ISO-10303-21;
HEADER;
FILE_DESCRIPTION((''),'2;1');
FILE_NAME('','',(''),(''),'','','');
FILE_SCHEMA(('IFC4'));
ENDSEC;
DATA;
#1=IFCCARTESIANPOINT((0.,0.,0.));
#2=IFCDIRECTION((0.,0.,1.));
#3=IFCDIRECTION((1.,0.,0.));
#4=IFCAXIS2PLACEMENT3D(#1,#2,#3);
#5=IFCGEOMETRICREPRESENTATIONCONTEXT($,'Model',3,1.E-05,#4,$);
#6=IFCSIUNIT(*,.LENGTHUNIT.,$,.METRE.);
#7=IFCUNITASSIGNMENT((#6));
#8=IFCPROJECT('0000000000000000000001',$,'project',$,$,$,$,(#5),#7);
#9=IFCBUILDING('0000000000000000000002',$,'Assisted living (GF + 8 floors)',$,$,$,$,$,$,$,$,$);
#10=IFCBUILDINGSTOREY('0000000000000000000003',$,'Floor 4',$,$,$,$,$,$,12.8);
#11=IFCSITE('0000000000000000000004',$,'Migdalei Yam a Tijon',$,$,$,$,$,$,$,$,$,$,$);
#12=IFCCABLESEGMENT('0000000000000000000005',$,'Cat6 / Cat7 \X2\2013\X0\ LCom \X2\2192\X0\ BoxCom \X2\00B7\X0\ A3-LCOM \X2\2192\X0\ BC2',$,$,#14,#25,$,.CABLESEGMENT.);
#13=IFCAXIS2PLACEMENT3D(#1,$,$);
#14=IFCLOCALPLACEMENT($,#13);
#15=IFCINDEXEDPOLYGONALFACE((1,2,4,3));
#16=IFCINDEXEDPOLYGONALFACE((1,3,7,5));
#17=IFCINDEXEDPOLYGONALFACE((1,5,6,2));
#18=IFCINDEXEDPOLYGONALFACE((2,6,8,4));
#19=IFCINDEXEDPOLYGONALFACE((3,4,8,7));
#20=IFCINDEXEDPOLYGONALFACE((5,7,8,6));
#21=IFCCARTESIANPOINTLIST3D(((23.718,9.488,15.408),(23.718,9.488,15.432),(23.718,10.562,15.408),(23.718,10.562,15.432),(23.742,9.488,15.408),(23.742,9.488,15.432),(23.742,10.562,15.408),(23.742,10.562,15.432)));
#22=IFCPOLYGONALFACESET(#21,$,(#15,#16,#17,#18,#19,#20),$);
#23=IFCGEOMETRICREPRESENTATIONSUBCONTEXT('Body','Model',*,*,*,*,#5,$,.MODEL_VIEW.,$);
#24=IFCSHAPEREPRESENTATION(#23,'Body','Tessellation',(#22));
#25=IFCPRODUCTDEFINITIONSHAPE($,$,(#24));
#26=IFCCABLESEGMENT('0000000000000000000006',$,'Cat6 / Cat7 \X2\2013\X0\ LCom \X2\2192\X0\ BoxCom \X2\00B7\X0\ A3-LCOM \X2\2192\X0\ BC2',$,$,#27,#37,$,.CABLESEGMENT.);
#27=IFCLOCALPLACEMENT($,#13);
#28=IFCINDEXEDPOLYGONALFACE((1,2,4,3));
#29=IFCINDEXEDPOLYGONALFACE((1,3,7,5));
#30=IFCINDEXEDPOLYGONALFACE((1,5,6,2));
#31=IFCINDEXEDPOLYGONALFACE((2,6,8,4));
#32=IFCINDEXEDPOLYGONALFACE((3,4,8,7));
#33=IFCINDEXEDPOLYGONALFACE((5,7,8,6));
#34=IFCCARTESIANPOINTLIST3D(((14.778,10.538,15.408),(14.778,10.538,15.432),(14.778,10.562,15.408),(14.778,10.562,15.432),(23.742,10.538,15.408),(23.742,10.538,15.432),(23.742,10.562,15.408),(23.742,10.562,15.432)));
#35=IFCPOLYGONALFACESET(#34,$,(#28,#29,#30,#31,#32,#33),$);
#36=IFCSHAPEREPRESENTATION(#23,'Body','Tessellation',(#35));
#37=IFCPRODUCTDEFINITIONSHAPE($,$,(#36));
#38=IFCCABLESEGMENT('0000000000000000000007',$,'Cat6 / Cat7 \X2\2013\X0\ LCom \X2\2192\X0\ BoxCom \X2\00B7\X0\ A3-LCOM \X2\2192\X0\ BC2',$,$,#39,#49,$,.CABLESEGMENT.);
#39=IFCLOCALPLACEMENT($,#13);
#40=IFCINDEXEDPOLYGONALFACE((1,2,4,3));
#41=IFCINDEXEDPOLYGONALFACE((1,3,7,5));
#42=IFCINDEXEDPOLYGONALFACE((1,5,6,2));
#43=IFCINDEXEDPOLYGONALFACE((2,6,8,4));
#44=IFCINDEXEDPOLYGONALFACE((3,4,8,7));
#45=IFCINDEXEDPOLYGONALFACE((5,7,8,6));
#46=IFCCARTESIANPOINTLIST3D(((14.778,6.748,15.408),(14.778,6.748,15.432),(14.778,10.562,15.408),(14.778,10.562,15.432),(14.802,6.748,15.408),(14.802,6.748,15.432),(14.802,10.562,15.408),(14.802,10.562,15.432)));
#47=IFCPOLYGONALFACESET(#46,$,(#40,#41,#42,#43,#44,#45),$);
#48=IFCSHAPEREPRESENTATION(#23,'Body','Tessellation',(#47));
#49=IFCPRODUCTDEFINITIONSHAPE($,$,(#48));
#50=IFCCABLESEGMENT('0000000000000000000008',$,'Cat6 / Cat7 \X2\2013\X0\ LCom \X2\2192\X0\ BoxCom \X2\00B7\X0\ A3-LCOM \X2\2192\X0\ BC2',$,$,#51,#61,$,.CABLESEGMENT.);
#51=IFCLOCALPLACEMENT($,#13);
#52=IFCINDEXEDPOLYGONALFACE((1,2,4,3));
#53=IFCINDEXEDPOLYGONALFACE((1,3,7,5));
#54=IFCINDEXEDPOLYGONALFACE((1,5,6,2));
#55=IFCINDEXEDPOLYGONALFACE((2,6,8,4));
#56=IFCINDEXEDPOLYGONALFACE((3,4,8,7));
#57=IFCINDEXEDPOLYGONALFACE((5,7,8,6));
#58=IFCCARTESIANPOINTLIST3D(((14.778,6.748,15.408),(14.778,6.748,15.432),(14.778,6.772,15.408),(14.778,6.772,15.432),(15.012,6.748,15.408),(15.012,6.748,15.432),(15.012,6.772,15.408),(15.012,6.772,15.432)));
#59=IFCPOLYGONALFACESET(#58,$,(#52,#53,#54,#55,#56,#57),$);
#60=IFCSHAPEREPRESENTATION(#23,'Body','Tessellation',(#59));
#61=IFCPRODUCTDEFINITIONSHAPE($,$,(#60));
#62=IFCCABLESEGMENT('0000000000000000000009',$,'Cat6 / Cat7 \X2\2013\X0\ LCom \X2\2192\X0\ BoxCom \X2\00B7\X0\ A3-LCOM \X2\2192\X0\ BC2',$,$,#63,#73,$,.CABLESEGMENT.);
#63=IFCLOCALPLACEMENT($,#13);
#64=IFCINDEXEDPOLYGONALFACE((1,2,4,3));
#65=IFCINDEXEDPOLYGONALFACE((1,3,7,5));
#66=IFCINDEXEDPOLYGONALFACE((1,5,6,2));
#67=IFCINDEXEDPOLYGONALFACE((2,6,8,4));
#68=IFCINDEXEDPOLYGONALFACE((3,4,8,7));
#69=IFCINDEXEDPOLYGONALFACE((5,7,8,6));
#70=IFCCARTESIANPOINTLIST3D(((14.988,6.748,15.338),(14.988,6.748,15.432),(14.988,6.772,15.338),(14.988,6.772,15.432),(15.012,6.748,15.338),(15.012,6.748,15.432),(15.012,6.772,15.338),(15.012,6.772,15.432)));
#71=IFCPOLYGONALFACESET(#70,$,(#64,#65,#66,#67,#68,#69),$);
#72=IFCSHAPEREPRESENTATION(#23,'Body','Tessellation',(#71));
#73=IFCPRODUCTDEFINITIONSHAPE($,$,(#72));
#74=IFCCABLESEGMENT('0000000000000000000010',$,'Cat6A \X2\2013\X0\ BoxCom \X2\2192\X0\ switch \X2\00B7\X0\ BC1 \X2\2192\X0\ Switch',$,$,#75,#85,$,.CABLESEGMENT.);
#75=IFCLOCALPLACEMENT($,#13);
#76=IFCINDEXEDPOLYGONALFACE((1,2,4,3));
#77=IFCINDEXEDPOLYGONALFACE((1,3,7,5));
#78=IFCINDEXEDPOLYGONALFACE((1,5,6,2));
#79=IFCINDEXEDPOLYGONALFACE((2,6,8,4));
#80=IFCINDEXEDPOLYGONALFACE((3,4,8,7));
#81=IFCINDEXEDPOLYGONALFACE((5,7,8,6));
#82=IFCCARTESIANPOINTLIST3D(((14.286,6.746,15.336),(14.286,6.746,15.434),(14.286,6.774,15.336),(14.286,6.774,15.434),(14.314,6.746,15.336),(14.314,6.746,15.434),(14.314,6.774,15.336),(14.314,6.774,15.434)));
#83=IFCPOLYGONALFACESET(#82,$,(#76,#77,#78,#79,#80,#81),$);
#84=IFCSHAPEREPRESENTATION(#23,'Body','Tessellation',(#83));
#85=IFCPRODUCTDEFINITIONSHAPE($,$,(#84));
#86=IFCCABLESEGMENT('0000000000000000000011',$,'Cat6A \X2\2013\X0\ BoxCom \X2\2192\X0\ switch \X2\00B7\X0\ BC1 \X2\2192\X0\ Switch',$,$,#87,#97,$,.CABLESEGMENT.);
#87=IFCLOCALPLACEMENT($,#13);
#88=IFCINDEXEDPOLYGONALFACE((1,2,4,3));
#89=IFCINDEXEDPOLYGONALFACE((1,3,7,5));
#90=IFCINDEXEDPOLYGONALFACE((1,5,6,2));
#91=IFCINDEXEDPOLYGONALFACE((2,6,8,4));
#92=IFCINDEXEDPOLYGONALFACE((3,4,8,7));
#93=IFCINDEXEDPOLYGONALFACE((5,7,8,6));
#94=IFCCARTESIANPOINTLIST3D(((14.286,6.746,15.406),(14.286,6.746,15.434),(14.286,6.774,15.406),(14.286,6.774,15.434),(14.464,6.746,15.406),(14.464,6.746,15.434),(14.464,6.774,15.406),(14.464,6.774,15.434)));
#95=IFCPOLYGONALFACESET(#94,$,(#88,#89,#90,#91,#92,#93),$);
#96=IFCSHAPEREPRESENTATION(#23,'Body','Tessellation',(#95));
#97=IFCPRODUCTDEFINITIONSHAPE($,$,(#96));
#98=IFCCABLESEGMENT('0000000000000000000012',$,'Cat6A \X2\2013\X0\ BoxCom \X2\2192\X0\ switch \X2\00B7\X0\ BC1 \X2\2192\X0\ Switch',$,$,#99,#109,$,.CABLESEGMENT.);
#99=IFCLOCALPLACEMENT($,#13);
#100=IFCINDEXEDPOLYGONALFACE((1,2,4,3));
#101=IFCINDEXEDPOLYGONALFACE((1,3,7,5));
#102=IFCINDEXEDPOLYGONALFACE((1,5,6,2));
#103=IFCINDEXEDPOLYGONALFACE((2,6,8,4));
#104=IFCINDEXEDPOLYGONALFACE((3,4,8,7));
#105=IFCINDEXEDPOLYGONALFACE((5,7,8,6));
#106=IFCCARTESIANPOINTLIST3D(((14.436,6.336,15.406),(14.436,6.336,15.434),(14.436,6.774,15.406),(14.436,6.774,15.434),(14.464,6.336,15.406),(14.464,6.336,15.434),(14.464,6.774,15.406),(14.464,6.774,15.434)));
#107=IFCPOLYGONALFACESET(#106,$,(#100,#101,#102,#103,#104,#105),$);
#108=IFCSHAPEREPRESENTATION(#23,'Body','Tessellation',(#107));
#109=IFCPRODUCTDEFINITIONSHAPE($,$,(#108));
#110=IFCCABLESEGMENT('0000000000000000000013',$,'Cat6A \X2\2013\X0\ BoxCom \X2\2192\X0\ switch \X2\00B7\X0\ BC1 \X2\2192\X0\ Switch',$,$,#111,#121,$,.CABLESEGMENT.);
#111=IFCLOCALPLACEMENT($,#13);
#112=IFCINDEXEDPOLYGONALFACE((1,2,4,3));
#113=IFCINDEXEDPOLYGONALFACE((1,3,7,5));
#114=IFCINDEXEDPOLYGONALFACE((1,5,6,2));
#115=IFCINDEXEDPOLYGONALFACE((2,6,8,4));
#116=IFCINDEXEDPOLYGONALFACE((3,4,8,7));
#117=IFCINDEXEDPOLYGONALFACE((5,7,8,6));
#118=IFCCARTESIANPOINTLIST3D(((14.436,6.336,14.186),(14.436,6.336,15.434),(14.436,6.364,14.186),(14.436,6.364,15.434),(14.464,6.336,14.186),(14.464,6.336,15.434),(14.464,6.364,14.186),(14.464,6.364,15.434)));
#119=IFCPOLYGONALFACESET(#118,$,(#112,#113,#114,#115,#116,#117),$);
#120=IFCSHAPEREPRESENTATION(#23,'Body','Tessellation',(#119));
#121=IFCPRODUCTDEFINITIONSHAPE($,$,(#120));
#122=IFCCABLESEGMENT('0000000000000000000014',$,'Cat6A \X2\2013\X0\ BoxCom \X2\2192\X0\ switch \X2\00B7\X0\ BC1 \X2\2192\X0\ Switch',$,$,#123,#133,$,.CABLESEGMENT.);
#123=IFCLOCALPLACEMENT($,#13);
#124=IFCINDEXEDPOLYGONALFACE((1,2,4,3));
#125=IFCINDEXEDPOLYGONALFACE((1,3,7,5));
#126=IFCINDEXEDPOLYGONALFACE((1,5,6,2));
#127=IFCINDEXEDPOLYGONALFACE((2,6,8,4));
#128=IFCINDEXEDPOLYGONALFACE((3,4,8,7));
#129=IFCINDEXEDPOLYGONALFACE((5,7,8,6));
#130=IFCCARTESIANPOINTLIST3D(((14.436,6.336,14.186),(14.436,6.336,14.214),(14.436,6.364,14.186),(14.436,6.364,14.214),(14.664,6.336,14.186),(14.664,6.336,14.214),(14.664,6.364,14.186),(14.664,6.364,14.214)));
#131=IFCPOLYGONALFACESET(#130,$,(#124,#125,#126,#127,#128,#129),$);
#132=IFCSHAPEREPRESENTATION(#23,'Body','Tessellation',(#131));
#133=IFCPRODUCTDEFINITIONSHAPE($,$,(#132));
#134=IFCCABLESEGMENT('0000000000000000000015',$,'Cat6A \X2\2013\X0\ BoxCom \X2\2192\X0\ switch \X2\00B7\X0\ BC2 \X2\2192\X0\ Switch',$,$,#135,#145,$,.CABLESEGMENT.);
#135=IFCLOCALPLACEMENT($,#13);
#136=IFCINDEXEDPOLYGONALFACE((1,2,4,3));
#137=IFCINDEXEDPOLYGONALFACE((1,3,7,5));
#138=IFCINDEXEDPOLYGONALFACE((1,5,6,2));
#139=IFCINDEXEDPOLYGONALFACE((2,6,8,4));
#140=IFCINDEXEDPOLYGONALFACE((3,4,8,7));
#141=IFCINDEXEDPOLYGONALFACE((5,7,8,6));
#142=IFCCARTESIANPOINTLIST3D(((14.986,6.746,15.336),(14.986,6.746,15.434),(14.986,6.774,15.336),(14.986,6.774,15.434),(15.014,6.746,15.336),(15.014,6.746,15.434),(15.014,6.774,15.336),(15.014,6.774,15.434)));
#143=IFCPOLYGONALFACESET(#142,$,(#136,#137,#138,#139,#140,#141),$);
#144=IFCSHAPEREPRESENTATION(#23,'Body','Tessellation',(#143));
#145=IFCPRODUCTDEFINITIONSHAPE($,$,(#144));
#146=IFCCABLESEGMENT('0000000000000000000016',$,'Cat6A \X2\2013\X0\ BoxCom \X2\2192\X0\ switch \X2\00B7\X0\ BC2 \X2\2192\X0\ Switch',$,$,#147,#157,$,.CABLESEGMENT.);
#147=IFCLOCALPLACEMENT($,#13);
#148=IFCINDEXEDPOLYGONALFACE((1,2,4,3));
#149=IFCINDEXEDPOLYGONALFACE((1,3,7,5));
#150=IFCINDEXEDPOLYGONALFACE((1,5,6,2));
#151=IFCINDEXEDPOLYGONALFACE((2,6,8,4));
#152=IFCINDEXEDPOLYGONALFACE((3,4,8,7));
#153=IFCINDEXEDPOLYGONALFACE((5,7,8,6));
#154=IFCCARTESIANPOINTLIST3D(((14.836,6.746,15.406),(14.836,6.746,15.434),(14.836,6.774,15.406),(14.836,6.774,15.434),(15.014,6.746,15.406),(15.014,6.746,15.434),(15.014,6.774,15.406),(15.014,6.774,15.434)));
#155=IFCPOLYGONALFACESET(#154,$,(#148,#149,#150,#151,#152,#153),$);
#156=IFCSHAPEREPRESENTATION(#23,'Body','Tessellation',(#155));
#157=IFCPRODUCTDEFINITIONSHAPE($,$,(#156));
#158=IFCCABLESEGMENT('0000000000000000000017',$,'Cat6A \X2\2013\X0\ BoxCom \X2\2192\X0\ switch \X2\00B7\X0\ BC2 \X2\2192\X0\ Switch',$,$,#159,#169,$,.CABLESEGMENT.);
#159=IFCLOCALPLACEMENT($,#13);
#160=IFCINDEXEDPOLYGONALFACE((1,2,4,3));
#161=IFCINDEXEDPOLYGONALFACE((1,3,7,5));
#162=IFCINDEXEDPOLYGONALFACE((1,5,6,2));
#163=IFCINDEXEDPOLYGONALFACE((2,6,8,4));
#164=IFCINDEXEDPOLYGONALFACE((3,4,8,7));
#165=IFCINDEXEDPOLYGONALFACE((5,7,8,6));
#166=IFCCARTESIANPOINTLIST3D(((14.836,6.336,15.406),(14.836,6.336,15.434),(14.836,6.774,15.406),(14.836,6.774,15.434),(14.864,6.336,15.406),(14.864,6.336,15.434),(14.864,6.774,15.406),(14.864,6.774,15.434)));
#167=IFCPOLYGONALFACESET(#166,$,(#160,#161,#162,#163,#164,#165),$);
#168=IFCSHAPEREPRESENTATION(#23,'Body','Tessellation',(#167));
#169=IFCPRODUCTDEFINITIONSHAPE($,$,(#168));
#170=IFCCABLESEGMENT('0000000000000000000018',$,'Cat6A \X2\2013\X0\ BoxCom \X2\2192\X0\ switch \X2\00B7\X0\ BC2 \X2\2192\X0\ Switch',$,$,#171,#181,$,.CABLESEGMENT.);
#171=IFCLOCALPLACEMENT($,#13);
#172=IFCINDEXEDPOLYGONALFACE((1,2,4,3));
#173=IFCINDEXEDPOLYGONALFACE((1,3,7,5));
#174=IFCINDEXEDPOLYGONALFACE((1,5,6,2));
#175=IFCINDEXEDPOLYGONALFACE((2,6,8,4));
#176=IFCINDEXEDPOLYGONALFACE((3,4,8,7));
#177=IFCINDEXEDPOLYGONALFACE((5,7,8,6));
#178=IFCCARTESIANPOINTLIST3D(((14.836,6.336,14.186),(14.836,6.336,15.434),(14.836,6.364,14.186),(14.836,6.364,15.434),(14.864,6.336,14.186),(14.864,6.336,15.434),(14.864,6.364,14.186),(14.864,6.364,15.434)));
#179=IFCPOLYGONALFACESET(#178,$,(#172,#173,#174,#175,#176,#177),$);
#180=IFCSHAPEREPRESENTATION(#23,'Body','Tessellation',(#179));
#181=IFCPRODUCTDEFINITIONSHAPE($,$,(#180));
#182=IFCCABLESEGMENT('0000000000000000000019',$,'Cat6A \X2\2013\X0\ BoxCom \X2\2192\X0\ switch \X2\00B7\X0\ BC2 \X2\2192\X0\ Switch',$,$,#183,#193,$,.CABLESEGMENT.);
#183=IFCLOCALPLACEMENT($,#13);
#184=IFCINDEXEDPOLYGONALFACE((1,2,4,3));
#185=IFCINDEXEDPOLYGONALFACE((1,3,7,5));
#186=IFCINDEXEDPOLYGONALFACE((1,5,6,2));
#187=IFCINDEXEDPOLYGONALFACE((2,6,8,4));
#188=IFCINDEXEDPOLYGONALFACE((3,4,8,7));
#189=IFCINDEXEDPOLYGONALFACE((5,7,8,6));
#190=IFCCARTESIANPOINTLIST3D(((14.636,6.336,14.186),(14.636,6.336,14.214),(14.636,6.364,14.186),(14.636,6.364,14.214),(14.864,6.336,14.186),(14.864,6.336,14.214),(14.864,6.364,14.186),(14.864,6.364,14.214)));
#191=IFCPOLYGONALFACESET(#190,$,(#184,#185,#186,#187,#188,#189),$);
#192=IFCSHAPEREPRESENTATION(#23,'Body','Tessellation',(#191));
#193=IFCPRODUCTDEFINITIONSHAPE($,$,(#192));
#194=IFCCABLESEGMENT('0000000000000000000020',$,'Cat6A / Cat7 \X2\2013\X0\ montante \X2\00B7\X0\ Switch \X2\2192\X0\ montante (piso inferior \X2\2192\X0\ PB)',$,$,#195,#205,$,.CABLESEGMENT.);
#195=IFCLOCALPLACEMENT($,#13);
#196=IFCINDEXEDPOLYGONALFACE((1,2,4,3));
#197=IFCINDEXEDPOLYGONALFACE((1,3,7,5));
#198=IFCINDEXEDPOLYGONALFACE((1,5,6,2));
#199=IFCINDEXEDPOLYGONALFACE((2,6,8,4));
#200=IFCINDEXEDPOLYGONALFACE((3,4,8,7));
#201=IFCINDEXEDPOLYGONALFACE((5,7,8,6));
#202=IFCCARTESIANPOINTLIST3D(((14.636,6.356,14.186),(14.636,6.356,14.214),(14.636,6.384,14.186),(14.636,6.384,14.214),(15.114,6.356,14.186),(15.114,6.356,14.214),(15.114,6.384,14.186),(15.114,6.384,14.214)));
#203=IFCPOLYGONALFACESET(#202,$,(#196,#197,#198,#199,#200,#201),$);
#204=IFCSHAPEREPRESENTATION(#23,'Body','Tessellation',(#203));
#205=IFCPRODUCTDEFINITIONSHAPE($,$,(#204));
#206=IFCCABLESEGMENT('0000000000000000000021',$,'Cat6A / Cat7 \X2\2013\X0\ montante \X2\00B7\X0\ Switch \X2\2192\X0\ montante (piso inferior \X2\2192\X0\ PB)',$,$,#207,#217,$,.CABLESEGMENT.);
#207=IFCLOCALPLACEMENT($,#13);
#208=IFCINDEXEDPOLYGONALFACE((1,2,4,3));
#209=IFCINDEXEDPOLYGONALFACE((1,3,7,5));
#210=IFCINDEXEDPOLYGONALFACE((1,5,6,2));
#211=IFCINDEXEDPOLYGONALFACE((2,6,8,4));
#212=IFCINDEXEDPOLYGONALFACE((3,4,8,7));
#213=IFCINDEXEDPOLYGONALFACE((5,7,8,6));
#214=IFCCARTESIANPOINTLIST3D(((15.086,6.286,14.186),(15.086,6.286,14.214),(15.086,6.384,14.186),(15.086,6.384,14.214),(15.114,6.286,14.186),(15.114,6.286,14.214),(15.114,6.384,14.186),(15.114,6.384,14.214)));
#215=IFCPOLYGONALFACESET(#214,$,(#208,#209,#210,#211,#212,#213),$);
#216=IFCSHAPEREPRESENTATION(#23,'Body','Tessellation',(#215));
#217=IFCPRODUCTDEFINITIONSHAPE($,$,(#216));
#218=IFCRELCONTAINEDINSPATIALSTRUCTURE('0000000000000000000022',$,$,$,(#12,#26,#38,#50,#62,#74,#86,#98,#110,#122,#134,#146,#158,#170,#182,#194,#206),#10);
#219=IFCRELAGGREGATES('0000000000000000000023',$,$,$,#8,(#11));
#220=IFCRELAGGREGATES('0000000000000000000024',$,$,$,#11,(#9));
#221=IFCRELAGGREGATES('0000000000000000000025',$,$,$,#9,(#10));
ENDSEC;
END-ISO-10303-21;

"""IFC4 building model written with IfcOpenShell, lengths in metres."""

from ifc_helpers import new_model, si_unit, frame, origin_with_axes, context, subcontext, project, spatial, line, indexed_curve, outline, extrude, element, save


model = new_model("IFC4")

# Units and contexts
model_context = context("Model", 3, precision=1e-05, world=origin_with_axes())
body_context = subcontext(model_context, "Body", "Model", "MODEL_VIEW")
ifc_project = project(units=[si_unit("LENGTHUNIT", "METRE")], contexts=[model_context])

# Site, building, storey
site = spatial("IfcSite", under=ifc_project, Name="Migdalei Yam a Tijon")
building = spatial("IfcBuilding", under=site, Name="Assisted living (GF + 8 floors)")
storey = spatial("IfcBuildingStorey", under=building, Name="Floor 4", Elevation=12.8)

# Cable segments
element("IfcCableSegment", 1, inside=storey, Name="Cat6 / Cat7 – LCom → BoxCom · A3-LCOM → BC2", PredefinedType="CABLESEGMENT", context=body_context, shape_type="SweptSolid", body=[
    extrude(outline(indexed_curve([(0.0, 0.0), (0.024, 0.0), (0.024, 1.074), (0.0, 1.074)], segments=[line(1, 2, 3, 4, 1)])), frame((23.718, 9.488, 15.408), z_axis=(0.0, 0.0, 1.0), x_axis=(1.0, 0.0, 0.0)), (0.0, 0.0, 1.0), 0.024),
])
element("IfcCableSegment", 2, inside=storey, Name="Cat6 / Cat7 – LCom → BoxCom · A3-LCOM → BC2", PredefinedType="CABLESEGMENT", context=body_context, shape_type="SweptSolid", body=[
    extrude(outline(indexed_curve([(0.0, 0.0), (8.964, 0.0), (8.964, 0.024), (0.0, 0.024)], segments=[line(1, 2, 3, 4, 1)])), frame((14.778, 10.538, 15.408), z_axis=(0.0, 0.0, 1.0), x_axis=(1.0, 0.0, 0.0)), (0.0, 0.0, 1.0), 0.024),
])
element("IfcCableSegment", 3, inside=storey, Name="Cat6 / Cat7 – LCom → BoxCom · A3-LCOM → BC2", PredefinedType="CABLESEGMENT", context=body_context, shape_type="SweptSolid", body=[
    extrude(outline(indexed_curve([(0.0, 0.0), (0.024, 0.0), (0.024, 3.814), (0.0, 3.814)], segments=[line(1, 2, 3, 4, 1)])), frame((14.778, 6.748, 15.408), z_axis=(0.0, 0.0, 1.0), x_axis=(1.0, 0.0, 0.0)), (0.0, 0.0, 1.0), 0.024),
])
element("IfcCableSegment", 4, inside=storey, Name="Cat6 / Cat7 – LCom → BoxCom · A3-LCOM → BC2", PredefinedType="CABLESEGMENT", context=body_context, shape_type="SweptSolid", body=[
    extrude(outline(indexed_curve([(0.0, 0.0), (0.234, 0.0), (0.234, 0.024), (0.0, 0.024)], segments=[line(1, 2, 3, 4, 1)])), frame((14.778, 6.748, 15.408), z_axis=(0.0, 0.0, 1.0), x_axis=(1.0, 0.0, 0.0)), (0.0, 0.0, 1.0), 0.024),
])
element("IfcCableSegment", 5, inside=storey, Name="Cat6 / Cat7 – LCom → BoxCom · A3-LCOM → BC2", PredefinedType="CABLESEGMENT", context=body_context, shape_type="SweptSolid", body=[
    extrude(outline(indexed_curve([(0.0, 0.0), (0.024, 0.0), (0.024, 0.024), (0.0, 0.024)], segments=[line(1, 2, 3, 4, 1)])), frame((14.988, 6.748, 15.338), z_axis=(0.0, 0.0, 1.0), x_axis=(1.0, 0.0, 0.0)), (0.0, 0.0, 1.0), 0.094),
])
element("IfcCableSegment", 6, inside=storey, Name="Cat6A – BoxCom → switch · BC1 → Switch", PredefinedType="CABLESEGMENT", context=body_context, shape_type="SweptSolid", body=[
    extrude(outline(indexed_curve([(0.0, 0.0), (0.028, 0.0), (0.028, 0.028), (0.0, 0.028)], segments=[line(1, 2, 3, 4, 1)])), frame((14.286, 6.746, 15.336), z_axis=(0.0, 0.0, 1.0), x_axis=(1.0, 0.0, 0.0)), (0.0, 0.0, 1.0), 0.098),
])
element("IfcCableSegment", 7, inside=storey, Name="Cat6A – BoxCom → switch · BC1 → Switch", PredefinedType="CABLESEGMENT", context=body_context, shape_type="SweptSolid", body=[
    extrude(outline(indexed_curve([(0.0, 0.0), (0.178, 0.0), (0.178, 0.028), (0.0, 0.028)], segments=[line(1, 2, 3, 4, 1)])), frame((14.286, 6.746, 15.406), z_axis=(0.0, 0.0, 1.0), x_axis=(1.0, 0.0, 0.0)), (0.0, 0.0, 1.0), 0.028),
])
element("IfcCableSegment", 8, inside=storey, Name="Cat6A – BoxCom → switch · BC1 → Switch", PredefinedType="CABLESEGMENT", context=body_context, shape_type="SweptSolid", body=[
    extrude(outline(indexed_curve([(0.0, 0.0), (0.028, 0.0), (0.028, 0.438), (0.0, 0.438)], segments=[line(1, 2, 3, 4, 1)])), frame((14.436, 6.336, 15.406), z_axis=(0.0, 0.0, 1.0), x_axis=(1.0, 0.0, 0.0)), (0.0, 0.0, 1.0), 0.028),
])
element("IfcCableSegment", 9, inside=storey, Name="Cat6A – BoxCom → switch · BC1 → Switch", PredefinedType="CABLESEGMENT", context=body_context, shape_type="SweptSolid", body=[
    extrude(outline(indexed_curve([(0.0, 0.0), (0.028, 0.0), (0.028, 0.028), (0.0, 0.028)], segments=[line(1, 2, 3, 4, 1)])), frame((14.436, 6.336, 14.186), z_axis=(0.0, 0.0, 1.0), x_axis=(1.0, 0.0, 0.0)), (0.0, 0.0, 1.0), 1.248),
])
element("IfcCableSegment", 10, inside=storey, Name="Cat6A – BoxCom → switch · BC1 → Switch", PredefinedType="CABLESEGMENT", context=body_context, shape_type="SweptSolid", body=[
    extrude(outline(indexed_curve([(0.0, 0.0), (0.228, 0.0), (0.228, 0.028), (0.0, 0.028)], segments=[line(1, 2, 3, 4, 1)])), frame((14.436, 6.336, 14.186), z_axis=(0.0, 0.0, 1.0), x_axis=(1.0, 0.0, 0.0)), (0.0, 0.0, 1.0), 0.028),
])
element("IfcCableSegment", 11, inside=storey, Name="Cat6A – BoxCom → switch · BC2 → Switch", PredefinedType="CABLESEGMENT", context=body_context, shape_type="SweptSolid", body=[
    extrude(outline(indexed_curve([(0.0, 0.0), (0.028, 0.0), (0.028, 0.028), (0.0, 0.028)], segments=[line(1, 2, 3, 4, 1)])), frame((14.986, 6.746, 15.336), z_axis=(0.0, 0.0, 1.0), x_axis=(1.0, 0.0, 0.0)), (0.0, 0.0, 1.0), 0.098),
])
element("IfcCableSegment", 12, inside=storey, Name="Cat6A – BoxCom → switch · BC2 → Switch", PredefinedType="CABLESEGMENT", context=body_context, shape_type="SweptSolid", body=[
    extrude(outline(indexed_curve([(0.0, 0.0), (0.178, 0.0), (0.178, 0.028), (0.0, 0.028)], segments=[line(1, 2, 3, 4, 1)])), frame((14.836, 6.746, 15.406), z_axis=(0.0, 0.0, 1.0), x_axis=(1.0, 0.0, 0.0)), (0.0, 0.0, 1.0), 0.028),
])
element("IfcCableSegment", 13, inside=storey, Name="Cat6A – BoxCom → switch · BC2 → Switch", PredefinedType="CABLESEGMENT", context=body_context, shape_type="SweptSolid", body=[
    extrude(outline(indexed_curve([(0.0, 0.0), (0.028, 0.0), (0.028, 0.438), (0.0, 0.438)], segments=[line(1, 2, 3, 4, 1)])), frame((14.836, 6.336, 15.406), z_axis=(0.0, 0.0, 1.0), x_axis=(1.0, 0.0, 0.0)), (0.0, 0.0, 1.0), 0.028),
])
element("IfcCableSegment", 14, inside=storey, Name="Cat6A – BoxCom → switch · BC2 → Switch", PredefinedType="CABLESEGMENT", context=body_context, shape_type="SweptSolid", body=[
    extrude(outline(indexed_curve([(0.0, 0.0), (0.028, 0.0), (0.028, 0.028), (0.0, 0.028)], segments=[line(1, 2, 3, 4, 1)])), frame((14.836, 6.336, 14.186), z_axis=(0.0, 0.0, 1.0), x_axis=(1.0, 0.0, 0.0)), (0.0, 0.0, 1.0), 1.248),
])
element("IfcCableSegment", 15, inside=storey, Name="Cat6A – BoxCom → switch · BC2 → Switch", PredefinedType="CABLESEGMENT", context=body_context, shape_type="SweptSolid", body=[
    extrude(outline(indexed_curve([(0.0, 0.0), (0.228, 0.0), (0.228, 0.028), (0.0, 0.028)], segments=[line(1, 2, 3, 4, 1)])), frame((14.636, 6.336, 14.186), z_axis=(0.0, 0.0, 1.0), x_axis=(1.0, 0.0, 0.0)), (0.0, 0.0, 1.0), 0.028),
])
element("IfcCableSegment", 16, inside=storey, Name="Cat6A / Cat7 – montante · Switch → montante (piso inferior → PB)", PredefinedType="CABLESEGMENT", context=body_context, shape_type="SweptSolid", body=[
    extrude(outline(indexed_curve([(0.0, 0.0), (0.478, 0.0), (0.478, 0.028), (0.0, 0.028)], segments=[line(1, 2, 3, 4, 1)])), frame((14.636, 6.356, 14.186), z_axis=(0.0, 0.0, 1.0), x_axis=(1.0, 0.0, 0.0)), (0.0, 0.0, 1.0), 0.028),
])
element("IfcCableSegment", 17, inside=storey, Name="Cat6A / Cat7 – montante · Switch → montante (piso inferior → PB)", PredefinedType="CABLESEGMENT", context=body_context, shape_type="SweptSolid", body=[
    extrude(outline(indexed_curve([(0.0, 0.0), (0.028, 0.0), (0.028, 0.098), (0.0, 0.098)], segments=[line(1, 2, 3, 4, 1)])), frame((15.086, 6.286, 14.186), z_axis=(0.0, 0.0, 1.0), x_axis=(1.0, 0.0, 0.0)), (0.0, 0.0, 1.0), 0.028),
])

save(model, "model.ifc")
